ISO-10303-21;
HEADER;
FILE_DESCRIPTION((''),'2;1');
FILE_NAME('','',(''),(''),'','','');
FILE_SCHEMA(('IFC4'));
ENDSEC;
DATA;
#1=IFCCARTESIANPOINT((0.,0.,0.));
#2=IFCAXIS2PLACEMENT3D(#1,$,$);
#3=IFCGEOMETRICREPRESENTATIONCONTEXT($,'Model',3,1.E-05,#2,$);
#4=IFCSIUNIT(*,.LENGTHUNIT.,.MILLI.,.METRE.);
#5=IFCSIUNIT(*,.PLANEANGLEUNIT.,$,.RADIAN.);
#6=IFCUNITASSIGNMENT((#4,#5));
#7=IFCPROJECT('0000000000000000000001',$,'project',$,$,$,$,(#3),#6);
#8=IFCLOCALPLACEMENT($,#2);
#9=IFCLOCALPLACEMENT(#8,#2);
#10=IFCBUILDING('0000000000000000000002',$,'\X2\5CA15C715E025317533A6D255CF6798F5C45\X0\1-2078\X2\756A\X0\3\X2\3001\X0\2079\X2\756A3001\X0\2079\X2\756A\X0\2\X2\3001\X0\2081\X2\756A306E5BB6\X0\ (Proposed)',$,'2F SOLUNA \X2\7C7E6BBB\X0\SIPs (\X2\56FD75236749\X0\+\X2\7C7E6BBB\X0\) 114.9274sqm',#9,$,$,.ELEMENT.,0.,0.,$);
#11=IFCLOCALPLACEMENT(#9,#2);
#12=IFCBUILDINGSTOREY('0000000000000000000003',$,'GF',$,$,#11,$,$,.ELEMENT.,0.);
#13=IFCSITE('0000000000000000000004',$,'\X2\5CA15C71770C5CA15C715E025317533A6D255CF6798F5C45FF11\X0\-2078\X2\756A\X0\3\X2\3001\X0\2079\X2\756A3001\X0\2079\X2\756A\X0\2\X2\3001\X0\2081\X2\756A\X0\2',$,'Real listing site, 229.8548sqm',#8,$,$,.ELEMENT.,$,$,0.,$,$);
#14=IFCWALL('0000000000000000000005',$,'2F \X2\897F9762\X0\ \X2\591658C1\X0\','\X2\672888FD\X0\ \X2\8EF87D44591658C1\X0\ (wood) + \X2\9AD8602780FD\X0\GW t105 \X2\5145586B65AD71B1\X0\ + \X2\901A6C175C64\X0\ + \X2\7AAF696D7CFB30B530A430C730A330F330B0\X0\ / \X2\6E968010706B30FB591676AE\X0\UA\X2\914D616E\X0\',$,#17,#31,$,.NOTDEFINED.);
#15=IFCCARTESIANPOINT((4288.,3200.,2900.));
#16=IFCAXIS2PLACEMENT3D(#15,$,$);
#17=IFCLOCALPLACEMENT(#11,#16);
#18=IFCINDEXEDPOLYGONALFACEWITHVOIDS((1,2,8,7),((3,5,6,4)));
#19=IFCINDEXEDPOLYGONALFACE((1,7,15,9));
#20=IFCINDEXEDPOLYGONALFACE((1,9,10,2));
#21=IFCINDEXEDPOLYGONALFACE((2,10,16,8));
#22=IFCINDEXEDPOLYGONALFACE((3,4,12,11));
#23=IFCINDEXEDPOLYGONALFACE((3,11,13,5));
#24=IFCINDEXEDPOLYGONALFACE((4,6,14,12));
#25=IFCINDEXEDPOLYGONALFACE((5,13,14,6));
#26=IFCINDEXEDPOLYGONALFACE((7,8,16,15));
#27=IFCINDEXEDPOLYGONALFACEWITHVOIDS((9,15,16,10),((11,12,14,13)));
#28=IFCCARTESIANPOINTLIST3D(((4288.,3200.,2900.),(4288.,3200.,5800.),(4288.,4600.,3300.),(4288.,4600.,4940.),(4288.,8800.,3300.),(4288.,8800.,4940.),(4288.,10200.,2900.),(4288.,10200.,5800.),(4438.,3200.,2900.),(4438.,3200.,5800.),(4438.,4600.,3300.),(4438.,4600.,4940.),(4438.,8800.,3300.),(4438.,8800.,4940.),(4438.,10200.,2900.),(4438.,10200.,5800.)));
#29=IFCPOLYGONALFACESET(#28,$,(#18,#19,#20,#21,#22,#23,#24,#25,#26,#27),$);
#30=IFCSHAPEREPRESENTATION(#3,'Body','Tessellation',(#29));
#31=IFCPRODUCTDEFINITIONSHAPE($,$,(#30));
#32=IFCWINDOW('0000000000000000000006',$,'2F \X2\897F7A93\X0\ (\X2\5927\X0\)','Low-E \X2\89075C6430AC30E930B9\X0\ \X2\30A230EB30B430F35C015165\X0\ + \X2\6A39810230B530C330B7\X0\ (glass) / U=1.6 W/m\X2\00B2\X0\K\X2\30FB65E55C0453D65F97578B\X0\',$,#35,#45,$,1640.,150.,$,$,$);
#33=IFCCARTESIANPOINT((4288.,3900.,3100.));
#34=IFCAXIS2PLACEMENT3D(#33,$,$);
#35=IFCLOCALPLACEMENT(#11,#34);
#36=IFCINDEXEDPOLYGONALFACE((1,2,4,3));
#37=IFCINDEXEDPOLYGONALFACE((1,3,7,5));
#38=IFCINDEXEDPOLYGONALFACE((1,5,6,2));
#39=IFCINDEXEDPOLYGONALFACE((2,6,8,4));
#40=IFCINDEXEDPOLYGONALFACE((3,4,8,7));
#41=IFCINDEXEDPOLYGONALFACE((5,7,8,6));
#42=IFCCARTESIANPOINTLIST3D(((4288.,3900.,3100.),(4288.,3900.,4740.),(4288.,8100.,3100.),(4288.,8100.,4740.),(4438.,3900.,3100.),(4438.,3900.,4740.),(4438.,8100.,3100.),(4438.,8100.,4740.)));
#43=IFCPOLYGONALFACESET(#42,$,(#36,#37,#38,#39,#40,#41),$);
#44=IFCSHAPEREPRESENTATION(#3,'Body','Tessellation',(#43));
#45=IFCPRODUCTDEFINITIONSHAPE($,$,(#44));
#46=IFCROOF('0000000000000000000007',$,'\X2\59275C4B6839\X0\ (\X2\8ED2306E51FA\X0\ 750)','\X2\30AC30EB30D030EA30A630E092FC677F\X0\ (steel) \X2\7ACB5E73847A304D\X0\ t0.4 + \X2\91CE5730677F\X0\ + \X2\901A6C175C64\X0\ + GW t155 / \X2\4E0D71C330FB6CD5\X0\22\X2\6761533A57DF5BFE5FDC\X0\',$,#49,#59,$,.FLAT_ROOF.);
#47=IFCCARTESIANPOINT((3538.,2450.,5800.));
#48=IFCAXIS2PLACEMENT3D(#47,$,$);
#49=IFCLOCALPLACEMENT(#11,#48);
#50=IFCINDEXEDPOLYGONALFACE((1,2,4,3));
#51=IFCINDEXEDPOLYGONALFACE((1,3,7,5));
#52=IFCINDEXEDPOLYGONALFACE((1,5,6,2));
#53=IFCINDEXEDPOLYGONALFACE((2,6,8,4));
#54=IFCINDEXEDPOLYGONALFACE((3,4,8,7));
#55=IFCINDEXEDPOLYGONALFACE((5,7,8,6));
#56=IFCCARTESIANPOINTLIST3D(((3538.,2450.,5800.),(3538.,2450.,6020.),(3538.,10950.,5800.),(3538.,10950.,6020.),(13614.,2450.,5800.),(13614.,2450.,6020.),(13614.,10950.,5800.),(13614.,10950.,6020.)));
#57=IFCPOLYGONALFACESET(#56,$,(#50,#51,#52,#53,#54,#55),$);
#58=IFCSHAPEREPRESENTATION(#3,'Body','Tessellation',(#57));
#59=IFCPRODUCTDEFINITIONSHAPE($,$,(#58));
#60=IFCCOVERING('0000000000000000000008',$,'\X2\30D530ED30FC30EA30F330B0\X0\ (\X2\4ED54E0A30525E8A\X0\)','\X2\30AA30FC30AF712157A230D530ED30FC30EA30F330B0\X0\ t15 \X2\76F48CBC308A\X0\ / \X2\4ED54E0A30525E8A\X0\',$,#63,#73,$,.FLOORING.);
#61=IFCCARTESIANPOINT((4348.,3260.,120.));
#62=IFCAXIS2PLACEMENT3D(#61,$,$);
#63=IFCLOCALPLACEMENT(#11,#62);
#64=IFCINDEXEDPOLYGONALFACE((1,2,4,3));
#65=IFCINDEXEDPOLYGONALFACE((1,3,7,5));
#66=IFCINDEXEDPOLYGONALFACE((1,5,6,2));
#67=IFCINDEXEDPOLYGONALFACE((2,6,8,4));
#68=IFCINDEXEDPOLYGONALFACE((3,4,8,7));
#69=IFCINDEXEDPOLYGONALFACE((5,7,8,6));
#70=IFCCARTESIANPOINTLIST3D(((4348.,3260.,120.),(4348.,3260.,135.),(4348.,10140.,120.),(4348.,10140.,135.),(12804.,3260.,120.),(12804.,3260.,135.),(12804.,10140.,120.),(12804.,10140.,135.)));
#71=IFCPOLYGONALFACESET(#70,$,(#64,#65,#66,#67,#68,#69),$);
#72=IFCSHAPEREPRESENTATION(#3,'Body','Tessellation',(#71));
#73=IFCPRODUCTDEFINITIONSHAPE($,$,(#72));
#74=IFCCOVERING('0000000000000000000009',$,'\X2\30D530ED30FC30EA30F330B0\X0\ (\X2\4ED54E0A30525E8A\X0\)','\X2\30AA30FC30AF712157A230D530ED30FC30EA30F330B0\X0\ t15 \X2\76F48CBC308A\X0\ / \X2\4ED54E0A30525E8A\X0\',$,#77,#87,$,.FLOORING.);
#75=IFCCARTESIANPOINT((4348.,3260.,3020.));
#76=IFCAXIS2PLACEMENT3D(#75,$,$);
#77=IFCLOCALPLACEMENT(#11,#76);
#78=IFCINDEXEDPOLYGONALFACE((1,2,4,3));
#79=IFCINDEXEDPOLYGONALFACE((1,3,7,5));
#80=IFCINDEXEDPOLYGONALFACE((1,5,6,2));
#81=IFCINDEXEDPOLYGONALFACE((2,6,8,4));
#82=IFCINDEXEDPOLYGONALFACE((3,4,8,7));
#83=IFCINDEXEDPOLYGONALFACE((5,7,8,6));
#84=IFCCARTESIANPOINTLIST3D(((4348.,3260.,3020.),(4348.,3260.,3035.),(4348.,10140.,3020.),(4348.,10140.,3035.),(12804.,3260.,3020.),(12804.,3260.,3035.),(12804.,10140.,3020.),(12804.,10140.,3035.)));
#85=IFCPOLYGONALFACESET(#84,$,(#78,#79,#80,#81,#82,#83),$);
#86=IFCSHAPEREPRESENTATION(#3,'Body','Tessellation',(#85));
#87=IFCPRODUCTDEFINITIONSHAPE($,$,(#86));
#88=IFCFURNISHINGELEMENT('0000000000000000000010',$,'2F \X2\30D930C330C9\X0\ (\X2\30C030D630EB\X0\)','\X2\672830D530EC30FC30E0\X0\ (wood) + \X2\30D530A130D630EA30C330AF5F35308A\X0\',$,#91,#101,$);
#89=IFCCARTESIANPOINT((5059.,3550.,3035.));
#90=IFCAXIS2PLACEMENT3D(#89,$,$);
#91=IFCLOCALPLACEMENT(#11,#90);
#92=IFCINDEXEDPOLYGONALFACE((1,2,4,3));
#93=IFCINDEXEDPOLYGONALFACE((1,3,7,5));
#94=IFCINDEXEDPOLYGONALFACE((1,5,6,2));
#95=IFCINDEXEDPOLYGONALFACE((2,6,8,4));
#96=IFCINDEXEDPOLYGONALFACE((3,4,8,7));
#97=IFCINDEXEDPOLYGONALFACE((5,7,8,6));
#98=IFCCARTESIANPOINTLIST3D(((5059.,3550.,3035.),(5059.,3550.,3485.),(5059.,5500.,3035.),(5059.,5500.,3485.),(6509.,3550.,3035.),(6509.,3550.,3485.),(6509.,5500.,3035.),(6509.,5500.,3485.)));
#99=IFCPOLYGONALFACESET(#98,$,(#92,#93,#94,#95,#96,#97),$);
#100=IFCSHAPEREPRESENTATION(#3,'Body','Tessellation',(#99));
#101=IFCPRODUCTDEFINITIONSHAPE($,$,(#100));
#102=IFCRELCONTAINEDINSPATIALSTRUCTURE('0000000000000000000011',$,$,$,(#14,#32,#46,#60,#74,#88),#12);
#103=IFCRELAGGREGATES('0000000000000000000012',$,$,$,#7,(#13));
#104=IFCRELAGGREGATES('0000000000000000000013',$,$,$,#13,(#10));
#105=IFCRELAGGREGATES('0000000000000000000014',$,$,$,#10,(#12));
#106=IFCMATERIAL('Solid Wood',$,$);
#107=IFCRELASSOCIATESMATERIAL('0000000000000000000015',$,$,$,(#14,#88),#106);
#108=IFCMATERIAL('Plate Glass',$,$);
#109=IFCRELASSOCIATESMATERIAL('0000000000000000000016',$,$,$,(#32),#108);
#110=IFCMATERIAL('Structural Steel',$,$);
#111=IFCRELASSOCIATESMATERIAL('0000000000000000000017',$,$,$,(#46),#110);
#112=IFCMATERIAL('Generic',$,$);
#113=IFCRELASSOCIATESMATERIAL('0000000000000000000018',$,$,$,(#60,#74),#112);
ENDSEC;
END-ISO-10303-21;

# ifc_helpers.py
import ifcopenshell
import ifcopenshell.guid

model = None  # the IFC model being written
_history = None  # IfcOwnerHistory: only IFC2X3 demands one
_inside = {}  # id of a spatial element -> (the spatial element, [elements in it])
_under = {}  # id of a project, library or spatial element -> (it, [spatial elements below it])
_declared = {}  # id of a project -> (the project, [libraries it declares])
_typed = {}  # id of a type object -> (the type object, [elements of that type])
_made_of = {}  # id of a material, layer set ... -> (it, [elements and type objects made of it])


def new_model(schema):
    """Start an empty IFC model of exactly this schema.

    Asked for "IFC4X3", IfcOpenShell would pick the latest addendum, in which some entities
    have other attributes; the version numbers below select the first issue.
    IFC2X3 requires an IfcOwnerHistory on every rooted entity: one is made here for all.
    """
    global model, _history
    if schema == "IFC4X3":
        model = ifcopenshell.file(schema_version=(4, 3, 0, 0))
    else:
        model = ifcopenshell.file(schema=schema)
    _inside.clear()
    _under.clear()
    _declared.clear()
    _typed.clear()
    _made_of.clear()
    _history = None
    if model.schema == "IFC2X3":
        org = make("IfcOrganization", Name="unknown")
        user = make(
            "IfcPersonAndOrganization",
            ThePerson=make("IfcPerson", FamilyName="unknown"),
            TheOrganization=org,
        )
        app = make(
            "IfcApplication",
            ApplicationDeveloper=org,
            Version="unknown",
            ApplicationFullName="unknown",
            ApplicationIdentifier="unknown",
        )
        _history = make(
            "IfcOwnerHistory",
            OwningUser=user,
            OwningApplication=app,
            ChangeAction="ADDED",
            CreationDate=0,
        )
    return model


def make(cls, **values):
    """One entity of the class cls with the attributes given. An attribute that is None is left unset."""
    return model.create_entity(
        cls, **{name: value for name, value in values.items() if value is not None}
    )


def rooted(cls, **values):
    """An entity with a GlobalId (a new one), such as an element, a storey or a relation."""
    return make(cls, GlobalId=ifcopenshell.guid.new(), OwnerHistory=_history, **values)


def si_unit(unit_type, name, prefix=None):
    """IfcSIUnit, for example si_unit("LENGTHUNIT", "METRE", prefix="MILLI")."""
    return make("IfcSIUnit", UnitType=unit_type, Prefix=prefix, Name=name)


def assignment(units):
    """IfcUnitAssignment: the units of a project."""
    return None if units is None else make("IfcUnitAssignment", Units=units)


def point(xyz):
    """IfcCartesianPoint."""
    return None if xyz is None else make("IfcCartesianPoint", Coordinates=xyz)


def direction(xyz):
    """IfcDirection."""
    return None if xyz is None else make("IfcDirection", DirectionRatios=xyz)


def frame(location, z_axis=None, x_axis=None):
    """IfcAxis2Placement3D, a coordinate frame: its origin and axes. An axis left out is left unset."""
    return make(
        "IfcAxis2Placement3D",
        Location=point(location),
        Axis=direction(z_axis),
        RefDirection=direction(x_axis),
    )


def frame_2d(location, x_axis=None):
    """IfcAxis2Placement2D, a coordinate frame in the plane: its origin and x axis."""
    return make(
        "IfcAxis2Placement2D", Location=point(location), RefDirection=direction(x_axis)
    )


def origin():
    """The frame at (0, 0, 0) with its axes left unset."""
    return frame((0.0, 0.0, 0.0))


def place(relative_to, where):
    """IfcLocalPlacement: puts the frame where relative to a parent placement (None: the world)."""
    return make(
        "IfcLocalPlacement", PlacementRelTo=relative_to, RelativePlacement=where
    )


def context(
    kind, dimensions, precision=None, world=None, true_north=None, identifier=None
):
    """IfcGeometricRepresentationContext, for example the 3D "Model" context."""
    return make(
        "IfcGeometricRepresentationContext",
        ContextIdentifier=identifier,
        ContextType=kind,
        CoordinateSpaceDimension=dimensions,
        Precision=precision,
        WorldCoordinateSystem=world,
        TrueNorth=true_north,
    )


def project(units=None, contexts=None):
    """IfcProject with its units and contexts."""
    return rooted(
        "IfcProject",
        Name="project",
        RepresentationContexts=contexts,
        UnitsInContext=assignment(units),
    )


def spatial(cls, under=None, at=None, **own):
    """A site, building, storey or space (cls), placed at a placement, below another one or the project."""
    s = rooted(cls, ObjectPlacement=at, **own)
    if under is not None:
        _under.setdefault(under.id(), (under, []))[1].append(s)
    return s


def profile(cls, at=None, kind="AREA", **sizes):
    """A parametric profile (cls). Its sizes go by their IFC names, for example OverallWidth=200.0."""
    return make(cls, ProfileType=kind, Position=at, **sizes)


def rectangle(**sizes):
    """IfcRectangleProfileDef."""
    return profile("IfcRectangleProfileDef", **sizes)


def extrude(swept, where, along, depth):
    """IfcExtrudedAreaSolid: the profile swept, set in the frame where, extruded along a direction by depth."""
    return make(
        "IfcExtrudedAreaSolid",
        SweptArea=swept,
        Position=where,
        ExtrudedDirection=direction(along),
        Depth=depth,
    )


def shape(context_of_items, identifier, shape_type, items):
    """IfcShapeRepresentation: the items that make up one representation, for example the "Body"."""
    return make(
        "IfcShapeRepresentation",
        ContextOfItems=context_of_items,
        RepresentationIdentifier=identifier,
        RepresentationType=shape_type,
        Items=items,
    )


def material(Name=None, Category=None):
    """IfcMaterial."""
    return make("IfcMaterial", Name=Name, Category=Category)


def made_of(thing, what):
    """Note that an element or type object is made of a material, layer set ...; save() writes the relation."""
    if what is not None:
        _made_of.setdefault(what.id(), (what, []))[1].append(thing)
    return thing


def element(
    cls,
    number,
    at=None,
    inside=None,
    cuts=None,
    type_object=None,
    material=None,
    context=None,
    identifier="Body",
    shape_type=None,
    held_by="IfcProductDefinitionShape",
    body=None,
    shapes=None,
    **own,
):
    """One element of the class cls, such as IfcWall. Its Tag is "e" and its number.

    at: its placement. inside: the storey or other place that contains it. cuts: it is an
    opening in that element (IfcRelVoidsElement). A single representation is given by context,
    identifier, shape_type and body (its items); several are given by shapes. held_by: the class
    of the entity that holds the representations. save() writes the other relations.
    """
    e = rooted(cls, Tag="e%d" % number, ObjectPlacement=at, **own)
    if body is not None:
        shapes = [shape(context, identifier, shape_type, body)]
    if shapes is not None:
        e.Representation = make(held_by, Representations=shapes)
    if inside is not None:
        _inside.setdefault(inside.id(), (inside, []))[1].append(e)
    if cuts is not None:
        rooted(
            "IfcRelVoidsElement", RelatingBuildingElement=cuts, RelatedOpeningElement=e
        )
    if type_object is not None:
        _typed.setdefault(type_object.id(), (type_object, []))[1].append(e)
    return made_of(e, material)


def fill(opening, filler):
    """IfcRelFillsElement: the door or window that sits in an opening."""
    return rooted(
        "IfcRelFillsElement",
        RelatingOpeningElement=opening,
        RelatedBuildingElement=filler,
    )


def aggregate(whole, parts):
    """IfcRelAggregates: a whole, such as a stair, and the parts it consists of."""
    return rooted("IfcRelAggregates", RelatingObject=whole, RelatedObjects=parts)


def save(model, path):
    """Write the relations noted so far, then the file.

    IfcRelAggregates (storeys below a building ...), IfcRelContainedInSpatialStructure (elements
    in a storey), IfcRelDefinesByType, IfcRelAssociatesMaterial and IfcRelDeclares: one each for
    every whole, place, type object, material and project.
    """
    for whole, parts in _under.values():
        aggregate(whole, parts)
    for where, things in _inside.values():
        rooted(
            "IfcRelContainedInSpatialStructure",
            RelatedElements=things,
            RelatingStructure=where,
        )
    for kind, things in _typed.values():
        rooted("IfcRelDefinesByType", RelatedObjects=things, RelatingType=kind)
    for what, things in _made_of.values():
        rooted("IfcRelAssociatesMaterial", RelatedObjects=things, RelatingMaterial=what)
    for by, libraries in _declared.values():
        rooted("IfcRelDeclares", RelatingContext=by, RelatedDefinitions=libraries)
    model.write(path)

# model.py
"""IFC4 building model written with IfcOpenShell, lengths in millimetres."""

from ifc_helpers import new_model, si_unit, frame, frame_2d, origin, place, context, project, spatial, rectangle, extrude, material, element, fill, save


model = new_model("IFC4")

# Units and contexts
model_context = context("Model", 3, precision=1e-05, world=origin())
ifc_project = project(units=[si_unit("LENGTHUNIT", "METRE", prefix="MILLI"), si_unit("PLANEANGLEUNIT", "RADIAN")], contexts=[model_context])

# Site, building, storey
site_placement = place(None, origin())
site = spatial("IfcSite", under=ifc_project, at=site_placement, Name="岡山県岡山市北区津島福居１-2078番3、2079番、2079番2、2081番2", ObjectType="Real listing site, 229.8548sqm", CompositionType="ELEMENT", RefElevation=0.0)
building_placement = place(site_placement, origin())
building = spatial("IfcBuilding", under=site, at=building_placement, Name="岡山市北区津島福居1-2078番3、2079番、2079番2、2081番の家 (Proposed)", ObjectType="2F SOLUNA 籾殻SIPs (国産杉+籾殻) 114.9274sqm", CompositionType="ELEMENT", ElevationOfRefHeight=0.0, ElevationOfTerrain=0.0)
storey_placement = place(building_placement, origin())
storey = spatial("IfcBuildingStorey", under=building, at=storey_placement, Name="GF", CompositionType="ELEMENT", Elevation=0.0)

# Shared definitions
ifc_material_1 = material(Name="Solid Wood")

# Shared definitions
ifc_material_2 = material(Name="Plate Glass")

# Wall, opening, window
wall_1_placement = place(storey_placement, frame((4288.0, 3200.0, 2900.0)))
wall_1 = element("IfcWall", 1, at=wall_1_placement, inside=storey, material=ifc_material_1, Name="2F 西面 外壁", Description="木製 軸組外壁 (wood) + 高性能GW t105 充填断熱 + 通気層 + 窯業系サイディング / 準耐火・外皮UA配慮", PredefinedType="NOTDEFINED", context=model_context, shape_type="SweptSolid", body=[
    extrude(rectangle(XDim=150.0, YDim=7000.0, at=frame_2d((75.0, 3500.0))), frame((4288.0, 3200.0, 2900.0)), (0.0, 0.0, 1.0), 2900.0),
])
opening_1_placement = place(storey_placement, frame((4288.0, 3900.0, 3100.0)))
opening_1 = element("IfcOpeningElement", 2, at=opening_1_placement, cuts=wall_1, PredefinedType="NOTDEFINED", context=model_context, shape_type="SweptSolid", body=[
    extrude(rectangle(XDim=150.0, YDim=4200.0, at=frame_2d((75.0, 2100.0))), frame((4288.0, 3900.0, 3100.0)), (0.0, 0.0, 1.0), 1640.0),
])
window_1_placement = place(storey_placement, frame((4288.0, 3900.0, 3100.0)))
window_1 = element("IfcWindow", 3, at=window_1_placement, inside=storey, material=ifc_material_2, Name="2F 西窓 (大)", Description="Low-E 複層ガラス アルゴン封入 + 樹脂サッシ (glass) / U=1.6 W/m²K・日射取得型", OverallHeight=1640.0, OverallWidth=150.0, context=model_context, shape_type="SweptSolid", body=[
    extrude(rectangle(XDim=150.0, YDim=4200.0, at=frame_2d((75.0, 2100.0))), frame((4288.0, 3900.0, 3100.0)), (0.0, 0.0, 1.0), 1640.0),
])
fill(opening_1, window_1)

# Roof
ifc_material_3 = material(Name="Structural Steel")
roof_placement = place(storey_placement, frame((3538.0, 2450.0, 5800.0)))
element("IfcRoof", 4, at=roof_placement, inside=storey, material=ifc_material_3, Name="大屋根 (軒の出 750)", Description="ガルバリウム鋼板 (steel) 立平葺き t0.4 + 野地板 + 通気層 + GW t155 / 不燃・法22条区域対応", PredefinedType="FLAT_ROOF", context=model_context, shape_type="SweptSolid", body=[
    extrude(rectangle(XDim=10076.0, YDim=8500.0, at=frame_2d((5038.0, 4250.0))), frame((3538.0, 2450.0, 5800.0)), (0.0, 0.0, 1.0), 220.0),
])

# Coverings
ifc_material_4 = material(Name="Generic")
covering_1_placement = place(storey_placement, frame((4348.0, 3260.0, 120.0)))
element("IfcCovering", 5, at=covering_1_placement, inside=storey, material=ifc_material_4, Name="フローリング (仕上げ床)", Description="オーク無垢フローリング t15 直貼り / 仕上げ床", PredefinedType="FLOORING", context=model_context, shape_type="SweptSolid", body=[
    extrude(rectangle(XDim=8456.0, YDim=6880.0, at=frame_2d((4228.0, 3440.0))), frame((4348.0, 3260.0, 120.0)), (0.0, 0.0, 1.0), 15.0),
])
covering_2_placement = place(storey_placement, frame((4348.0, 3260.0, 3020.0)))
element("IfcCovering", 6, at=covering_2_placement, inside=storey, material=ifc_material_4, Name="フローリング (仕上げ床)", Description="オーク無垢フローリング t15 直貼り / 仕上げ床", PredefinedType="FLOORING", context=model_context, shape_type="SweptSolid", body=[
    extrude(rectangle(XDim=8456.0, YDim=6880.0, at=frame_2d((4228.0, 3440.0))), frame((4348.0, 3260.0, 3020.0)), (0.0, 0.0, 1.0), 15.0),
])

# Furnishing element
furnishing_placement = place(storey_placement, frame((5059.0, 3550.0, 3035.0)))
element("IfcFurnishingElement", 7, at=furnishing_placement, inside=storey, material=ifc_material_1, Name="2F ベッド (ダブル)", Description="木フレーム (wood) + ファブリック張り", context=model_context, shape_type="SweptSolid", body=[
    extrude(rectangle(XDim=1450.0, YDim=1950.0, at=frame_2d((725.0, 975.0))), frame((5059.0, 3550.0, 3035.0)), (0.0, 0.0, 1.0), 450.0),
])

save(model, "model.ifc")
